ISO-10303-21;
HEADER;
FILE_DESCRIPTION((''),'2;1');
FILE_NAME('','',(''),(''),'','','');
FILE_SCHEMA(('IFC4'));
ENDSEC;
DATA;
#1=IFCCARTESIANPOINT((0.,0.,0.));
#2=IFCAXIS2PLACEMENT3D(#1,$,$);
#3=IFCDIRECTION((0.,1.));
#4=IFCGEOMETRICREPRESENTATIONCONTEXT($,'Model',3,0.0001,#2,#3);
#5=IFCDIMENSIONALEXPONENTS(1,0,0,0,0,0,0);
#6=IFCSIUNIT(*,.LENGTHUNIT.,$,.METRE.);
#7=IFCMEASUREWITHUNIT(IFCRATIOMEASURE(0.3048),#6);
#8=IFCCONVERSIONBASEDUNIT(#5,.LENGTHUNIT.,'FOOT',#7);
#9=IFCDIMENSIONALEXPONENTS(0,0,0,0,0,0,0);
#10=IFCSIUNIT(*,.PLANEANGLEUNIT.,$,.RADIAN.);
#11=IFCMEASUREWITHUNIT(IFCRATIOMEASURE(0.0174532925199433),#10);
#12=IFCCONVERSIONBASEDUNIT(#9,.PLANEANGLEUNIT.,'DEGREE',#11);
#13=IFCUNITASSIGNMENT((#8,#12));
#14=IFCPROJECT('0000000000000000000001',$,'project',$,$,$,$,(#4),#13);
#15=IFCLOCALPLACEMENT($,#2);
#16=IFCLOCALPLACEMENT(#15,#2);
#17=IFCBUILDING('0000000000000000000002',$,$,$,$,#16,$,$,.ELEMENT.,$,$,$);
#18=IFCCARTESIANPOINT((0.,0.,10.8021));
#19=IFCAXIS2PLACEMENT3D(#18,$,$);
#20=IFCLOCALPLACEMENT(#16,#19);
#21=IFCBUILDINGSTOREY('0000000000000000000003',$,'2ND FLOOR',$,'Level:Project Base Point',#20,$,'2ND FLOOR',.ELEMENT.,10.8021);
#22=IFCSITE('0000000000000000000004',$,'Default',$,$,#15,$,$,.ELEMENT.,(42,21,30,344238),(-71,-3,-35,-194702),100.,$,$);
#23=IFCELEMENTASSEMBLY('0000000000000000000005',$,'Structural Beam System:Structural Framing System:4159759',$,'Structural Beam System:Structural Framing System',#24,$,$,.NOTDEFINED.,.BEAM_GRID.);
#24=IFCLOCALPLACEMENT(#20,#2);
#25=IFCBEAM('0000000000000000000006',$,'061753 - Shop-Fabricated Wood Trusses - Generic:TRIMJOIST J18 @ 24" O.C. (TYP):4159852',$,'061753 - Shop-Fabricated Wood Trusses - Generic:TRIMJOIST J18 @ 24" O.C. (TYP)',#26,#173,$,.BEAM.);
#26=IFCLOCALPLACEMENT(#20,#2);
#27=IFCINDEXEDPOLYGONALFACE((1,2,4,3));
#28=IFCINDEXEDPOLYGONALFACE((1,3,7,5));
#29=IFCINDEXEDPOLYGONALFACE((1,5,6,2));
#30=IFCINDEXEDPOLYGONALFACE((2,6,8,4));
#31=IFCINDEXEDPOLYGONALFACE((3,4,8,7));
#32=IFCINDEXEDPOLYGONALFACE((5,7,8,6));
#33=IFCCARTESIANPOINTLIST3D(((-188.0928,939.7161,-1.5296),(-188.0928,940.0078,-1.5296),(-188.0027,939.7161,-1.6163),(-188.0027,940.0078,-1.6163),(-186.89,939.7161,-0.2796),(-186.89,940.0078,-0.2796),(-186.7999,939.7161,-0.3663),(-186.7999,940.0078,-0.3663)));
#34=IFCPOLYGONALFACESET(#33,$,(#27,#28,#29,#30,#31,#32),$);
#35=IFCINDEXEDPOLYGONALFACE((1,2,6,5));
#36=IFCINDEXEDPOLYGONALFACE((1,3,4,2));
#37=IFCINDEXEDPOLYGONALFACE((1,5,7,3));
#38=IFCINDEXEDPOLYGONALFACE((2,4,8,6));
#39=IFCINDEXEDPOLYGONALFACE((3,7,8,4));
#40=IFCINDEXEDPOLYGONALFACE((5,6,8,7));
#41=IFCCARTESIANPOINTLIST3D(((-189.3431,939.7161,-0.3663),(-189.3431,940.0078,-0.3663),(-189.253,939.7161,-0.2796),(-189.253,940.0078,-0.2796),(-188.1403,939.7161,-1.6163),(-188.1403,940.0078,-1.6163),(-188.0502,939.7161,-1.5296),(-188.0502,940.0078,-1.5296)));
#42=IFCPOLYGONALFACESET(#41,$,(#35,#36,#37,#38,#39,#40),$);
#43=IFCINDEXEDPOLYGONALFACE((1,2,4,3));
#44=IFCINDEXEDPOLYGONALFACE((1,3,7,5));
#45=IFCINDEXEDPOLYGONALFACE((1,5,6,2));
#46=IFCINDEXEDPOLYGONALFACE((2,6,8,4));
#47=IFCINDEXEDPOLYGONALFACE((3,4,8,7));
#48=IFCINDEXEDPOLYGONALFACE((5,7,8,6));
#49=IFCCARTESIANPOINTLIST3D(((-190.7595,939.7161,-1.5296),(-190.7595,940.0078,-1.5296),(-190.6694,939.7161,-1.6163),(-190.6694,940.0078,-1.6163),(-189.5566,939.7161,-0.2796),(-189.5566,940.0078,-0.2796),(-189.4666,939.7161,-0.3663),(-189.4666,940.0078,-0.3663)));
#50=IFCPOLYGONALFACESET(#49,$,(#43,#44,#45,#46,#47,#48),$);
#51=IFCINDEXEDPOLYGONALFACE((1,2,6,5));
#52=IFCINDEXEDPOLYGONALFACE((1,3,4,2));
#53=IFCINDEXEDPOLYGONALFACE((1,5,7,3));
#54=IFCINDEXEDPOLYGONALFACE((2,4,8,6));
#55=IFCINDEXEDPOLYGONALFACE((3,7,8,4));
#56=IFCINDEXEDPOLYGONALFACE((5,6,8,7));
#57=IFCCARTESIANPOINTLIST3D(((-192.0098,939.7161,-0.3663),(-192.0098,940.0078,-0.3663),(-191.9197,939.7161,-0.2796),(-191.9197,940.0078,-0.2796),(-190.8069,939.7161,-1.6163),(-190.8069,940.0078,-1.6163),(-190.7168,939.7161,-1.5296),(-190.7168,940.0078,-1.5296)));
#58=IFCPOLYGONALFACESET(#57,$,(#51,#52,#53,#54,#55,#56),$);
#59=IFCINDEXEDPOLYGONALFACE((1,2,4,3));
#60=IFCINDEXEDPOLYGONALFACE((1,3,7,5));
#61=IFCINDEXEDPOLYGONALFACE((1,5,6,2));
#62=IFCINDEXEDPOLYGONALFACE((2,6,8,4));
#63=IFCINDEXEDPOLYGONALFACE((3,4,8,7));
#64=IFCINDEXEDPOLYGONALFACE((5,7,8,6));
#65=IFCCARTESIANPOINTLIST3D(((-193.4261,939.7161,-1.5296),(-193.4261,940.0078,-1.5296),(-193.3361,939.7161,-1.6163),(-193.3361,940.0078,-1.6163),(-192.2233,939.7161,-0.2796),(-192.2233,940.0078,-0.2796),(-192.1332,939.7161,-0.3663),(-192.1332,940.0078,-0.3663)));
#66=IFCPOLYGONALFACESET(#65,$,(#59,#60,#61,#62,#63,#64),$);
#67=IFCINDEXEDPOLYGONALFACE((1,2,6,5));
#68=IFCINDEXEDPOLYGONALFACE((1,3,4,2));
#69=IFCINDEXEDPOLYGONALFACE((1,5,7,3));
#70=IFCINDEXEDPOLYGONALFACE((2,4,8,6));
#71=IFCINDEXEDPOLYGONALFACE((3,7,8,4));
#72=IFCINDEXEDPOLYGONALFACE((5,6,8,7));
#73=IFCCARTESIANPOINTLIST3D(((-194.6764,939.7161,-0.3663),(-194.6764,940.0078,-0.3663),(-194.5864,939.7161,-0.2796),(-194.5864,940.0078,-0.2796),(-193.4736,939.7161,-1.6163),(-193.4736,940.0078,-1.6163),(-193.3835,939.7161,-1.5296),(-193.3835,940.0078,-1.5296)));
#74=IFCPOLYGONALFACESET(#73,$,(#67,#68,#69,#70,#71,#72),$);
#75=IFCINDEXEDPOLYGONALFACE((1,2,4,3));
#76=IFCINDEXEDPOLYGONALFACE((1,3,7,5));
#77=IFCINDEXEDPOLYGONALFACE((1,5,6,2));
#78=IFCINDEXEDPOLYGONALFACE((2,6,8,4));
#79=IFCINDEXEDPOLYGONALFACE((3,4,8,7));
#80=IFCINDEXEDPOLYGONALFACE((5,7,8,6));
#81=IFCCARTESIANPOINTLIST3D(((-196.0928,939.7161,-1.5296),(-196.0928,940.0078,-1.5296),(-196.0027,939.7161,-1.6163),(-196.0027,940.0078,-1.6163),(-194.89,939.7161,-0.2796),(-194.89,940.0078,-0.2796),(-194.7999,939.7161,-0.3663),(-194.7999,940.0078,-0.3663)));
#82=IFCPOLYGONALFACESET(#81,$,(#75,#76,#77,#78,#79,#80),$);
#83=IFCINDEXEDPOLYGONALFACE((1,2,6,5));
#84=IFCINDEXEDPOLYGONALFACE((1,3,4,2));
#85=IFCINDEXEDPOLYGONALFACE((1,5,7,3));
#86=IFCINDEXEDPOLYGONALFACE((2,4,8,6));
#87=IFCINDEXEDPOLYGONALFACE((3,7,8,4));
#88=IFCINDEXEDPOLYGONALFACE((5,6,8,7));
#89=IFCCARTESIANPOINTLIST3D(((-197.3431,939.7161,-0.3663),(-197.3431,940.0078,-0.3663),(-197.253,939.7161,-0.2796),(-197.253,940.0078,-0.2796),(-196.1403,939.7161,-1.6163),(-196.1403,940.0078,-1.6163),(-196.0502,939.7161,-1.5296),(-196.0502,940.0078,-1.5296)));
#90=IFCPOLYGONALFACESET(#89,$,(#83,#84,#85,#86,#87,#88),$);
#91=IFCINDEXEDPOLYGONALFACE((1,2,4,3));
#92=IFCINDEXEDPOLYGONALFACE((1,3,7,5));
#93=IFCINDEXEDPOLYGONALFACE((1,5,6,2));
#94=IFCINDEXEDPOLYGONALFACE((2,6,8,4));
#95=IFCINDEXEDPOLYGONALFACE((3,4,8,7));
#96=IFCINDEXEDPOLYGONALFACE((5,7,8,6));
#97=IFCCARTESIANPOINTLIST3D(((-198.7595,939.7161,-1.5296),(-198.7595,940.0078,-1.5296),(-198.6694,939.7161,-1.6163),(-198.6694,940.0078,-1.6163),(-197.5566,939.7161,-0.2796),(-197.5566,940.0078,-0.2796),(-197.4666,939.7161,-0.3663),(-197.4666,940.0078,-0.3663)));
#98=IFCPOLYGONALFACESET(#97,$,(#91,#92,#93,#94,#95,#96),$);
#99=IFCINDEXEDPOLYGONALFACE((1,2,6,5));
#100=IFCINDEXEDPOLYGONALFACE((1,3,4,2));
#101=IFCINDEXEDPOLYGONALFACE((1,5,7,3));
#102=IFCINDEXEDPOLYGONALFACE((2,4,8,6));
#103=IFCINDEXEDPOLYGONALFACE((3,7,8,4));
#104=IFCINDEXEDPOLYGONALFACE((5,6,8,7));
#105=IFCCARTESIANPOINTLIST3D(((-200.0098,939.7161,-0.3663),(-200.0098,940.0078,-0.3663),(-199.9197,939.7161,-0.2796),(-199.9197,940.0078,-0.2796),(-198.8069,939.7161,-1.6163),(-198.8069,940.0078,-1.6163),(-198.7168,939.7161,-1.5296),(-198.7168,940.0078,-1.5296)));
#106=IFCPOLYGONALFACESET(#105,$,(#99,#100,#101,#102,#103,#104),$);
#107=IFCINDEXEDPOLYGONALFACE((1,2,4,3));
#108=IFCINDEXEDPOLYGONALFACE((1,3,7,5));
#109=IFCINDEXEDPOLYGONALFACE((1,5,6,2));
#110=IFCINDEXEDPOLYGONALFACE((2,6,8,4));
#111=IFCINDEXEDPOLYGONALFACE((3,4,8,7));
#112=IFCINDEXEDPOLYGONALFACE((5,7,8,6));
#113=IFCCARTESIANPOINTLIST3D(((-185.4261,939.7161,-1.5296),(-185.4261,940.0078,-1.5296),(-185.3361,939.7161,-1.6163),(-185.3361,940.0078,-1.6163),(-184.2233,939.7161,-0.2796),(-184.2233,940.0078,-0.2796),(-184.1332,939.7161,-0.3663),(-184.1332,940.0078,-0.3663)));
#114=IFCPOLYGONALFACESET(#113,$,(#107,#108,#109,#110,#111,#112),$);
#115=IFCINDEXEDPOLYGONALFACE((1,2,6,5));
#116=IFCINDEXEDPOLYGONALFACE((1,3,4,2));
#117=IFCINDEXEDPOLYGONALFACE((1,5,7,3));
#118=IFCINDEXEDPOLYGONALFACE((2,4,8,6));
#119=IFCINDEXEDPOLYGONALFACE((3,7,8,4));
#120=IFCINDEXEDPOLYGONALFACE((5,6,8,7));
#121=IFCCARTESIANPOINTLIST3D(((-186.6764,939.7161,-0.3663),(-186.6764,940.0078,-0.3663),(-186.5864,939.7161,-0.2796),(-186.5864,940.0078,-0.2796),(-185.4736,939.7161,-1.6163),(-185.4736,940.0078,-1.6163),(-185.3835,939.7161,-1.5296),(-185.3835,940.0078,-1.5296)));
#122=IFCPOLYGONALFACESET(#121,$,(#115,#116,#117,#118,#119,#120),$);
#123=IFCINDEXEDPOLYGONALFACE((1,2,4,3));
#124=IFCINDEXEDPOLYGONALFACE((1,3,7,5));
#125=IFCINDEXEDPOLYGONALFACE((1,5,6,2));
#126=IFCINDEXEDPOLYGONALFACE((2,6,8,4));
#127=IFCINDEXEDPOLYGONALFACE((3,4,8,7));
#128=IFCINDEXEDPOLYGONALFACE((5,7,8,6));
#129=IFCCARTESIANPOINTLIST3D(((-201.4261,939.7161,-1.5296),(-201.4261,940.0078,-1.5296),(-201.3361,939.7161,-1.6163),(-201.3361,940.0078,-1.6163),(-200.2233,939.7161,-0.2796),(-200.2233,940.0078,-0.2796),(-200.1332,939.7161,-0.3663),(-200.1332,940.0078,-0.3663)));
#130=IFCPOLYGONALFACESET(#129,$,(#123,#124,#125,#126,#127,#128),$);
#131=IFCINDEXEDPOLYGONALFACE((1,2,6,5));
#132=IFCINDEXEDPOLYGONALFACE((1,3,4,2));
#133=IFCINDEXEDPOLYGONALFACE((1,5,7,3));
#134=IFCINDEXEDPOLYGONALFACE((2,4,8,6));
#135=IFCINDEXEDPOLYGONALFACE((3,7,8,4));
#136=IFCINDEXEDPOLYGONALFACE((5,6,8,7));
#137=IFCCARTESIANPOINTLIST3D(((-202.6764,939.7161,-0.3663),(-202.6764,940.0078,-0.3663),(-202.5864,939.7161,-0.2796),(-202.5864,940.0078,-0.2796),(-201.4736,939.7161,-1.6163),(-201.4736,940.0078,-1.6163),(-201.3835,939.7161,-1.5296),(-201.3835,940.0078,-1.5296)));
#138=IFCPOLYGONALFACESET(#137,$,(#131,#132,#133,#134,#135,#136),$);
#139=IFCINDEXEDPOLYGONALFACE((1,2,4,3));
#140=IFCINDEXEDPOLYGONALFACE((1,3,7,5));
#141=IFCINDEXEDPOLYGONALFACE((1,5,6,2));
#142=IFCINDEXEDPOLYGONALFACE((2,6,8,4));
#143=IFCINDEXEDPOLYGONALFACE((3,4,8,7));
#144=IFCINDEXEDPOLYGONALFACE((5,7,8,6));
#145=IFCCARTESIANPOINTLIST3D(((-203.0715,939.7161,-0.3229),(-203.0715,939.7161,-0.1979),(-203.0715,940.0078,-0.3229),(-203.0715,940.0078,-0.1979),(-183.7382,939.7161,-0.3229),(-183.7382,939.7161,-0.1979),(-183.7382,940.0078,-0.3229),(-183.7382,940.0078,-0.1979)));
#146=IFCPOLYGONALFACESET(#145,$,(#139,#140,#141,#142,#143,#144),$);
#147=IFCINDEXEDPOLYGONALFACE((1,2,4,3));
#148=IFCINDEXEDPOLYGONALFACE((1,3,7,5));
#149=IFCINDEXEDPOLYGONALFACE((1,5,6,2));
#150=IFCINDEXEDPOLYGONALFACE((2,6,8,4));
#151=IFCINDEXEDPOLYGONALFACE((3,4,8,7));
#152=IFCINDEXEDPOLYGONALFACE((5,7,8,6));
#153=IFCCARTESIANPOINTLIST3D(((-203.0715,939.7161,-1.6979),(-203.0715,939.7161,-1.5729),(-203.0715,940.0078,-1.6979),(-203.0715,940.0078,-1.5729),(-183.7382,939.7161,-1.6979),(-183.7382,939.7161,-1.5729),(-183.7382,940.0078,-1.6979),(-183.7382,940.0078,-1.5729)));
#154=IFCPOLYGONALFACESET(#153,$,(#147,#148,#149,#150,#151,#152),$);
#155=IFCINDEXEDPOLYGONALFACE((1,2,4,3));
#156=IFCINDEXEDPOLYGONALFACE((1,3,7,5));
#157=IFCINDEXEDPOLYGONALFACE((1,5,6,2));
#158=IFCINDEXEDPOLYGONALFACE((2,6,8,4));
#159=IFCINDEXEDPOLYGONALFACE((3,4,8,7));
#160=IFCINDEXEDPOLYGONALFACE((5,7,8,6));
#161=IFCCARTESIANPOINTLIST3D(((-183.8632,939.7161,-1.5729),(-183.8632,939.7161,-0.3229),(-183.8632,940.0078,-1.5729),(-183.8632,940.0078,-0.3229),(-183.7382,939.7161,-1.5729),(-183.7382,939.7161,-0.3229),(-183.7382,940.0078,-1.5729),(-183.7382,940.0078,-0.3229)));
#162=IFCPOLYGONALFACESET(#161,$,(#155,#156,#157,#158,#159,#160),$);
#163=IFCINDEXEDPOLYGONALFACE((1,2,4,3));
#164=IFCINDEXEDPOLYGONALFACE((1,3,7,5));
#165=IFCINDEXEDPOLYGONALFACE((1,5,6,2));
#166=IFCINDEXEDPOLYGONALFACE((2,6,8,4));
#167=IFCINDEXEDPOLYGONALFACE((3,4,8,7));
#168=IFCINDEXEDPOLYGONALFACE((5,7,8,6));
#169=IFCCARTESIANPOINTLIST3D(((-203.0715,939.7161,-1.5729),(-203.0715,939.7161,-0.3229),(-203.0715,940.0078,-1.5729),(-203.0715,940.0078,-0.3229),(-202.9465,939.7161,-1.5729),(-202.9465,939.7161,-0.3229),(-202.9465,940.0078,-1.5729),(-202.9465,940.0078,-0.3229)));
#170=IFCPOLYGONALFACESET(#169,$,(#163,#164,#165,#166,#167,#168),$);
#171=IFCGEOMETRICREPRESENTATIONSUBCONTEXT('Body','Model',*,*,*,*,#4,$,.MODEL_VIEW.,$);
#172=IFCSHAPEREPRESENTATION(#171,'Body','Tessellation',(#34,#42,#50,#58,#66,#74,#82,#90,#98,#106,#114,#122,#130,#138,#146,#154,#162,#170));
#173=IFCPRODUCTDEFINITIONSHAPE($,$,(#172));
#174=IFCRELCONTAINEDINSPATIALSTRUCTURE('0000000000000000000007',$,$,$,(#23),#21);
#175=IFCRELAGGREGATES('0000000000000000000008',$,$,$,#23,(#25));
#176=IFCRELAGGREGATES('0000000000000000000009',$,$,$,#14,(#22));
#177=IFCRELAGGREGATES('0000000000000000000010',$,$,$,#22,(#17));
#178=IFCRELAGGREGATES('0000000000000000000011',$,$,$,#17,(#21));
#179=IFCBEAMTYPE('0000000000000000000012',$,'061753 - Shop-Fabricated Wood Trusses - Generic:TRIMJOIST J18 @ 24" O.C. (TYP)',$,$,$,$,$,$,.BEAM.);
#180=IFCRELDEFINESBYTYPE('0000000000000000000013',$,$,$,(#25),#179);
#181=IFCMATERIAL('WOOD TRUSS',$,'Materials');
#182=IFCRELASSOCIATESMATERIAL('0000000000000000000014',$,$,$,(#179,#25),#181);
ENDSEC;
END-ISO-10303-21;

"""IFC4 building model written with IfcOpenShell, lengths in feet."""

from ifc_helpers import new_model, entity, si_unit, converted_unit, direction, frame, frame_2d, origin, origin_2d_with_axis, place, context, subcontext, project, spatial, rectangle, extrude, source, transform, mapped, material, material_profile, profile_set, profile_usage, type_object, type_shapes, element, aggregate, save


model = new_model("IFC4")

# Units and contexts
model_context = context("Model", 3, precision=0.0001, world=origin(), true_north=direction((0.0, 1.0)))
body_context = subcontext(model_context, "Body", "Model", "MODEL_VIEW")
ifc_project = project(units=[converted_unit("LENGTHUNIT", "FOOT", entity("IfcRatioMeasure", 0.3048), si_unit("LENGTHUNIT", "METRE"), dimensions=[1, 0, 0, 0, 0, 0, 0]), converted_unit("PLANEANGLEUNIT", "DEGREE", entity("IfcRatioMeasure", 0.0174532925199433), si_unit("PLANEANGLEUNIT", "RADIAN"), dimensions=[0, 0, 0, 0, 0, 0, 0])], contexts=[model_context])

# Site, building, storey
site_placement = place(None, origin())
site = spatial("IfcSite", under=ifc_project, at=site_placement, Name="Default", CompositionType="ELEMENT", RefLatitude=(42, 21, 30, 344238), RefLongitude=(-71, -3, -35, -194702), RefElevation=100.0)
building_placement = place(site_placement, origin())
building = spatial("IfcBuilding", under=site, at=building_placement, CompositionType="ELEMENT")
storey_placement = place(building_placement, frame((0.0, 0.0, 10.8021)))
storey = spatial("IfcBuildingStorey", under=building, at=storey_placement, Name="2ND FLOOR", ObjectType="Level:Project Base Point", LongName="2ND FLOOR", CompositionType="ELEMENT", Elevation=10.8021)

# Element assembly, beam
ifc_material_1 = material(Name="WOOD TRUSS", Category="Materials")
ifc_material_profile_1 = material_profile(ifc_material_1, rectangle(XDim=1.7347, YDim=0.125, at=frame_2d((0.0, 0.0), x_axis=(1.0, 0.0))), Name="TRIMJOIST J18 @ 24\" O.C. (TYP)")
ifc_material_profile_2 = material_profile(ifc_material_1, rectangle(XDim=1.7347, YDim=0.125, at=frame_2d((0.0, 0.0), x_axis=(1.0, 0.0))), Name="TRIMJOIST J18 @ 24\" O.C. (TYP)")
ifc_material_profile_3 = material_profile(ifc_material_1, rectangle(XDim=1.7347, YDim=0.125, at=frame_2d((0.0, 0.0), x_axis=(1.0, 0.0))), Name="TRIMJOIST J18 @ 24\" O.C. (TYP)")
ifc_material_profile_4 = material_profile(ifc_material_1, rectangle(XDim=1.7347, YDim=0.125, at=frame_2d((0.0, 0.0), x_axis=(1.0, 0.0))), Name="TRIMJOIST J18 @ 24\" O.C. (TYP)")
ifc_material_profile_5 = material_profile(ifc_material_1, rectangle(XDim=1.7347, YDim=0.125, at=frame_2d((0.0, 0.0), x_axis=(1.0, 0.0))), Name="TRIMJOIST J18 @ 24\" O.C. (TYP)")
ifc_material_profile_6 = material_profile(ifc_material_1, rectangle(XDim=1.7347, YDim=0.125, at=frame_2d((0.0, 0.0), x_axis=(1.0, 0.0))), Name="TRIMJOIST J18 @ 24\" O.C. (TYP)")
ifc_material_profile_7 = material_profile(ifc_material_1, rectangle(XDim=1.7347, YDim=0.125, at=frame_2d((0.0, 0.0), x_axis=(1.0, 0.0))), Name="TRIMJOIST J18 @ 24\" O.C. (TYP)")
ifc_material_profile_8 = material_profile(ifc_material_1, rectangle(XDim=1.7347, YDim=0.125, at=frame_2d((0.0, 0.0), x_axis=(1.0, 0.0))), Name="TRIMJOIST J18 @ 24\" O.C. (TYP)")
ifc_material_profile_9 = material_profile(ifc_material_1, rectangle(XDim=1.7347, YDim=0.125, at=frame_2d((0.0, 0.0), x_axis=(1.0, 0.0))), Name="TRIMJOIST J18 @ 24\" O.C. (TYP)")
ifc_material_profile_10 = material_profile(ifc_material_1, rectangle(XDim=1.7347, YDim=0.125, at=origin_2d_with_axis()), Name="TRIMJOIST J18 @ 24\" O.C. (TYP)")
ifc_material_profile_11 = material_profile(ifc_material_1, rectangle(XDim=0.125, YDim=0.2917, at=origin_2d_with_axis()), Name="TRIMJOIST J18 @ 24\" O.C. (TYP)")
ifc_material_profile_12 = material_profile(ifc_material_1, rectangle(XDim=0.125, YDim=0.2917, at=origin_2d_with_axis()), Name="TRIMJOIST J18 @ 24\" O.C. (TYP)")
ifc_material_profile_13 = material_profile(ifc_material_1, rectangle(XDim=1.25, YDim=0.2917, at=origin_2d_with_axis()), Name="TRIMJOIST J18 @ 24\" O.C. (TYP)")
ifc_material_profile_14 = material_profile(ifc_material_1, rectangle(XDim=1.25, YDim=0.2917, at=origin_2d_with_axis()), Name="TRIMJOIST J18 @ 24\" O.C. (TYP)")
ifc_profile_set_1 = profile_set([ifc_material_profile_1, ifc_material_profile_2, ifc_material_profile_3, ifc_material_profile_4, ifc_material_profile_5, ifc_material_profile_6, ifc_material_profile_7, ifc_material_profile_8, ifc_material_profile_9, ifc_material_profile_10, ifc_material_profile_11, ifc_material_profile_12, ifc_material_profile_13, ifc_material_profile_14], Name="TRIMJOIST J18 @ 24\" O.C. (TYP)")
beam_type_1 = type_object("IfcBeamType", Name="061753 - Shop-Fabricated Wood Trusses - Generic:TRIMJOIST J18 @ 24\" O.C. (TYP)", PredefinedType="BEAM", material=ifc_profile_set_1)
shared_shape_1 = source(origin(), body_context, "Body", "SweptSolid", [
    extrude(rectangle(XDim=1.7347, YDim=0.125, at=frame_2d((0.0, 0.0), x_axis=(1.0, 0.0))), frame((5.9585, -0.1458, 0.0), z_axis=(0.0, 1.0, 0.0), x_axis=(0.693383, 0.0, 0.720569)), (0.0, 0.0, 1.0), 0.2917),
    extrude(rectangle(XDim=1.7347, YDim=0.125, at=origin_2d_with_axis()), frame((4.7082, -0.1458, 0.0), z_axis=(0.0, 1.0, 0.0), x_axis=(0.693383, 0.0, -0.720569)), (0.0, 0.0, 1.0), 0.2917),
    extrude(rectangle(XDim=1.7347, YDim=0.125, at=frame_2d((0.0, 0.0), x_axis=(1.0, 0.0))), frame((3.2918, -0.1458, 0.0), z_axis=(0.0, 1.0, 0.0), x_axis=(0.693383, 0.0, 0.720569)), (0.0, 0.0, 1.0), 0.2917),
    extrude(rectangle(XDim=1.7347, YDim=0.125, at=frame_2d((0.0, 0.0), x_axis=(1.0, 0.0))), frame((2.0415, -0.1458, 0.0), z_axis=(0.0, 1.0, 0.0), x_axis=(0.693383, 0.0, -0.720569)), (0.0, 0.0, 1.0), 0.2917),
    extrude(rectangle(XDim=1.7347, YDim=0.125, at=frame_2d((0.0, 0.0), x_axis=(1.0, 0.0))), frame((0.6251, -0.1458, 0.0), z_axis=(0.0, 1.0, 0.0), x_axis=(0.693383, 0.0, 0.720569)), (0.0, 0.0, 1.0), 0.2917),
    extrude(rectangle(XDim=1.7347, YDim=0.125, at=frame_2d((0.0, 0.0), x_axis=(1.0, 0.0))), frame((-0.6251, -0.1458, 0.0), z_axis=(0.0, 1.0, 0.0), x_axis=(0.693383, 0.0, -0.720569)), (0.0, 0.0, 1.0), 0.2917),
    extrude(rectangle(XDim=1.7347, YDim=0.125, at=frame_2d((0.0, 0.0), x_axis=(1.0, 0.0))), frame((-2.0415, -0.1458, 0.0), z_axis=(0.0, 1.0, 0.0), x_axis=(0.693383, 0.0, 0.720569)), (0.0, 0.0, 1.0), 0.2917),
    extrude(rectangle(XDim=1.7347, YDim=0.125, at=origin_2d_with_axis()), frame((-3.2918, -0.1458, 0.0), z_axis=(0.0, 1.0, 0.0), x_axis=(0.693383, 0.0, -0.720569)), (0.0, 0.0, 1.0), 0.2917),
    extrude(rectangle(XDim=1.7347, YDim=0.125, at=frame_2d((0.0, 0.0), x_axis=(1.0, 0.0))), frame((-4.7082, -0.1458, 0.0), z_axis=(0.0, 1.0, 0.0), x_axis=(0.693383, 0.0, 0.720569)), (0.0, 0.0, 1.0), 0.2917),
    extrude(rectangle(XDim=1.7347, YDim=0.125, at=frame_2d((0.0, 0.0), x_axis=(1.0, 0.0))), frame((-5.9585, -0.1458, 0.0), z_axis=(0.0, 1.0, 0.0), x_axis=(0.693383, 0.0, -0.720569)), (0.0, 0.0, 1.0), 0.2917),
    extrude(rectangle(XDim=1.7347, YDim=0.125, at=frame_2d((0.0, 0.0), x_axis=(1.0, 0.0))), frame((8.6251, -0.1458, 0.0), z_axis=(0.0, 1.0, 0.0), x_axis=(0.693383, 0.0, 0.720569)), (0.0, 0.0, 1.0), 0.2917),
    extrude(rectangle(XDim=1.7347, YDim=0.125, at=origin_2d_with_axis()), frame((7.3749, -0.1458, 0.0), z_axis=(0.0, 1.0, 0.0), x_axis=(0.693383, 0.0, -0.720569)), (0.0, 0.0, 1.0), 0.2917),
    extrude(rectangle(XDim=1.7347, YDim=0.125, at=frame_2d((0.0, 0.0), x_axis=(1.0, 0.0))), frame((-7.3749, -0.1458, 0.0), z_axis=(0.0, 1.0, 0.0), x_axis=(0.693383, 0.0, 0.720569)), (0.0, 0.0, 1.0), 0.2917),
    extrude(rectangle(XDim=1.7347, YDim=0.125, at=origin_2d_with_axis()), frame((-8.6251, -0.1458, 0.0), z_axis=(0.0, 1.0, 0.0), x_axis=(0.693383, 0.0, -0.720569)), (0.0, 0.0, 1.0), 0.2917),
    extrude(rectangle(XDim=0.125, YDim=0.2917, at=origin_2d_with_axis()), frame((-9.6667, 0.0, 0.6875), z_axis=(1.0, 0.0, 0.0), x_axis=(0.0, 0.0, -1.0)), (0.0, 0.0, 1.0), 19.3333),
    extrude(rectangle(XDim=0.125, YDim=0.2917, at=origin_2d_with_axis()), frame((-9.6667, 0.0, -0.6875), z_axis=(1.0, 0.0, 0.0), x_axis=(0.0, 0.0, -1.0)), (0.0, 0.0, 1.0), 19.3333),
    extrude(rectangle(XDim=1.25, YDim=0.2917, at=origin_2d_with_axis()), frame((9.5417, 0.0, 0.0), z_axis=(1.0, 0.0, 0.0), x_axis=(0.0, 0.0, -1.0)), (0.0, 0.0, 1.0), 0.125),
    extrude(rectangle(XDim=1.25, YDim=0.2917, at=origin_2d_with_axis()), frame((-9.6667, 0.0, 0.0), z_axis=(1.0, 0.0, 0.0), x_axis=(0.0, 0.0, -1.0)), (0.0, 0.0, 1.0), 0.125),
])
type_shapes(beam_type_1, [shared_shape_1])
assembly_1_placement = place(storey_placement, origin())
assembly_1 = element("IfcElementAssembly", 1, at=assembly_1_placement, inside=storey, Name="Structural Beam System:Structural Framing System:4159759", ObjectType="Structural Beam System:Structural Framing System", AssemblyPlace="NOTDEFINED", PredefinedType="BEAM_GRID")
ifc_profile_usage_1 = profile_usage(ifc_profile_set_1, cardinal=8)
beam_1_placement = place(assembly_1_placement, frame((-193.4048, 939.8619, -0.9479)))
beam_1 = element("IfcBeam", 2, at=beam_1_placement, type_object=beam_type_1, material=ifc_profile_usage_1, Name="061753 - Shop-Fabricated Wood Trusses - Generic:TRIMJOIST J18 @ 24\" O.C. (TYP):4159852", ObjectType="061753 - Shop-Fabricated Wood Trusses - Generic:TRIMJOIST J18 @ 24\" O.C. (TYP)", PredefinedType="BEAM", context=body_context, shape_type="MappedRepresentation", body=[
    mapped(shared_shape_1, transform((0.0, 0.0, 0.0), scale=1.0)),
])
aggregate(assembly_1, [beam_1])

save(model, "model.ifc")
